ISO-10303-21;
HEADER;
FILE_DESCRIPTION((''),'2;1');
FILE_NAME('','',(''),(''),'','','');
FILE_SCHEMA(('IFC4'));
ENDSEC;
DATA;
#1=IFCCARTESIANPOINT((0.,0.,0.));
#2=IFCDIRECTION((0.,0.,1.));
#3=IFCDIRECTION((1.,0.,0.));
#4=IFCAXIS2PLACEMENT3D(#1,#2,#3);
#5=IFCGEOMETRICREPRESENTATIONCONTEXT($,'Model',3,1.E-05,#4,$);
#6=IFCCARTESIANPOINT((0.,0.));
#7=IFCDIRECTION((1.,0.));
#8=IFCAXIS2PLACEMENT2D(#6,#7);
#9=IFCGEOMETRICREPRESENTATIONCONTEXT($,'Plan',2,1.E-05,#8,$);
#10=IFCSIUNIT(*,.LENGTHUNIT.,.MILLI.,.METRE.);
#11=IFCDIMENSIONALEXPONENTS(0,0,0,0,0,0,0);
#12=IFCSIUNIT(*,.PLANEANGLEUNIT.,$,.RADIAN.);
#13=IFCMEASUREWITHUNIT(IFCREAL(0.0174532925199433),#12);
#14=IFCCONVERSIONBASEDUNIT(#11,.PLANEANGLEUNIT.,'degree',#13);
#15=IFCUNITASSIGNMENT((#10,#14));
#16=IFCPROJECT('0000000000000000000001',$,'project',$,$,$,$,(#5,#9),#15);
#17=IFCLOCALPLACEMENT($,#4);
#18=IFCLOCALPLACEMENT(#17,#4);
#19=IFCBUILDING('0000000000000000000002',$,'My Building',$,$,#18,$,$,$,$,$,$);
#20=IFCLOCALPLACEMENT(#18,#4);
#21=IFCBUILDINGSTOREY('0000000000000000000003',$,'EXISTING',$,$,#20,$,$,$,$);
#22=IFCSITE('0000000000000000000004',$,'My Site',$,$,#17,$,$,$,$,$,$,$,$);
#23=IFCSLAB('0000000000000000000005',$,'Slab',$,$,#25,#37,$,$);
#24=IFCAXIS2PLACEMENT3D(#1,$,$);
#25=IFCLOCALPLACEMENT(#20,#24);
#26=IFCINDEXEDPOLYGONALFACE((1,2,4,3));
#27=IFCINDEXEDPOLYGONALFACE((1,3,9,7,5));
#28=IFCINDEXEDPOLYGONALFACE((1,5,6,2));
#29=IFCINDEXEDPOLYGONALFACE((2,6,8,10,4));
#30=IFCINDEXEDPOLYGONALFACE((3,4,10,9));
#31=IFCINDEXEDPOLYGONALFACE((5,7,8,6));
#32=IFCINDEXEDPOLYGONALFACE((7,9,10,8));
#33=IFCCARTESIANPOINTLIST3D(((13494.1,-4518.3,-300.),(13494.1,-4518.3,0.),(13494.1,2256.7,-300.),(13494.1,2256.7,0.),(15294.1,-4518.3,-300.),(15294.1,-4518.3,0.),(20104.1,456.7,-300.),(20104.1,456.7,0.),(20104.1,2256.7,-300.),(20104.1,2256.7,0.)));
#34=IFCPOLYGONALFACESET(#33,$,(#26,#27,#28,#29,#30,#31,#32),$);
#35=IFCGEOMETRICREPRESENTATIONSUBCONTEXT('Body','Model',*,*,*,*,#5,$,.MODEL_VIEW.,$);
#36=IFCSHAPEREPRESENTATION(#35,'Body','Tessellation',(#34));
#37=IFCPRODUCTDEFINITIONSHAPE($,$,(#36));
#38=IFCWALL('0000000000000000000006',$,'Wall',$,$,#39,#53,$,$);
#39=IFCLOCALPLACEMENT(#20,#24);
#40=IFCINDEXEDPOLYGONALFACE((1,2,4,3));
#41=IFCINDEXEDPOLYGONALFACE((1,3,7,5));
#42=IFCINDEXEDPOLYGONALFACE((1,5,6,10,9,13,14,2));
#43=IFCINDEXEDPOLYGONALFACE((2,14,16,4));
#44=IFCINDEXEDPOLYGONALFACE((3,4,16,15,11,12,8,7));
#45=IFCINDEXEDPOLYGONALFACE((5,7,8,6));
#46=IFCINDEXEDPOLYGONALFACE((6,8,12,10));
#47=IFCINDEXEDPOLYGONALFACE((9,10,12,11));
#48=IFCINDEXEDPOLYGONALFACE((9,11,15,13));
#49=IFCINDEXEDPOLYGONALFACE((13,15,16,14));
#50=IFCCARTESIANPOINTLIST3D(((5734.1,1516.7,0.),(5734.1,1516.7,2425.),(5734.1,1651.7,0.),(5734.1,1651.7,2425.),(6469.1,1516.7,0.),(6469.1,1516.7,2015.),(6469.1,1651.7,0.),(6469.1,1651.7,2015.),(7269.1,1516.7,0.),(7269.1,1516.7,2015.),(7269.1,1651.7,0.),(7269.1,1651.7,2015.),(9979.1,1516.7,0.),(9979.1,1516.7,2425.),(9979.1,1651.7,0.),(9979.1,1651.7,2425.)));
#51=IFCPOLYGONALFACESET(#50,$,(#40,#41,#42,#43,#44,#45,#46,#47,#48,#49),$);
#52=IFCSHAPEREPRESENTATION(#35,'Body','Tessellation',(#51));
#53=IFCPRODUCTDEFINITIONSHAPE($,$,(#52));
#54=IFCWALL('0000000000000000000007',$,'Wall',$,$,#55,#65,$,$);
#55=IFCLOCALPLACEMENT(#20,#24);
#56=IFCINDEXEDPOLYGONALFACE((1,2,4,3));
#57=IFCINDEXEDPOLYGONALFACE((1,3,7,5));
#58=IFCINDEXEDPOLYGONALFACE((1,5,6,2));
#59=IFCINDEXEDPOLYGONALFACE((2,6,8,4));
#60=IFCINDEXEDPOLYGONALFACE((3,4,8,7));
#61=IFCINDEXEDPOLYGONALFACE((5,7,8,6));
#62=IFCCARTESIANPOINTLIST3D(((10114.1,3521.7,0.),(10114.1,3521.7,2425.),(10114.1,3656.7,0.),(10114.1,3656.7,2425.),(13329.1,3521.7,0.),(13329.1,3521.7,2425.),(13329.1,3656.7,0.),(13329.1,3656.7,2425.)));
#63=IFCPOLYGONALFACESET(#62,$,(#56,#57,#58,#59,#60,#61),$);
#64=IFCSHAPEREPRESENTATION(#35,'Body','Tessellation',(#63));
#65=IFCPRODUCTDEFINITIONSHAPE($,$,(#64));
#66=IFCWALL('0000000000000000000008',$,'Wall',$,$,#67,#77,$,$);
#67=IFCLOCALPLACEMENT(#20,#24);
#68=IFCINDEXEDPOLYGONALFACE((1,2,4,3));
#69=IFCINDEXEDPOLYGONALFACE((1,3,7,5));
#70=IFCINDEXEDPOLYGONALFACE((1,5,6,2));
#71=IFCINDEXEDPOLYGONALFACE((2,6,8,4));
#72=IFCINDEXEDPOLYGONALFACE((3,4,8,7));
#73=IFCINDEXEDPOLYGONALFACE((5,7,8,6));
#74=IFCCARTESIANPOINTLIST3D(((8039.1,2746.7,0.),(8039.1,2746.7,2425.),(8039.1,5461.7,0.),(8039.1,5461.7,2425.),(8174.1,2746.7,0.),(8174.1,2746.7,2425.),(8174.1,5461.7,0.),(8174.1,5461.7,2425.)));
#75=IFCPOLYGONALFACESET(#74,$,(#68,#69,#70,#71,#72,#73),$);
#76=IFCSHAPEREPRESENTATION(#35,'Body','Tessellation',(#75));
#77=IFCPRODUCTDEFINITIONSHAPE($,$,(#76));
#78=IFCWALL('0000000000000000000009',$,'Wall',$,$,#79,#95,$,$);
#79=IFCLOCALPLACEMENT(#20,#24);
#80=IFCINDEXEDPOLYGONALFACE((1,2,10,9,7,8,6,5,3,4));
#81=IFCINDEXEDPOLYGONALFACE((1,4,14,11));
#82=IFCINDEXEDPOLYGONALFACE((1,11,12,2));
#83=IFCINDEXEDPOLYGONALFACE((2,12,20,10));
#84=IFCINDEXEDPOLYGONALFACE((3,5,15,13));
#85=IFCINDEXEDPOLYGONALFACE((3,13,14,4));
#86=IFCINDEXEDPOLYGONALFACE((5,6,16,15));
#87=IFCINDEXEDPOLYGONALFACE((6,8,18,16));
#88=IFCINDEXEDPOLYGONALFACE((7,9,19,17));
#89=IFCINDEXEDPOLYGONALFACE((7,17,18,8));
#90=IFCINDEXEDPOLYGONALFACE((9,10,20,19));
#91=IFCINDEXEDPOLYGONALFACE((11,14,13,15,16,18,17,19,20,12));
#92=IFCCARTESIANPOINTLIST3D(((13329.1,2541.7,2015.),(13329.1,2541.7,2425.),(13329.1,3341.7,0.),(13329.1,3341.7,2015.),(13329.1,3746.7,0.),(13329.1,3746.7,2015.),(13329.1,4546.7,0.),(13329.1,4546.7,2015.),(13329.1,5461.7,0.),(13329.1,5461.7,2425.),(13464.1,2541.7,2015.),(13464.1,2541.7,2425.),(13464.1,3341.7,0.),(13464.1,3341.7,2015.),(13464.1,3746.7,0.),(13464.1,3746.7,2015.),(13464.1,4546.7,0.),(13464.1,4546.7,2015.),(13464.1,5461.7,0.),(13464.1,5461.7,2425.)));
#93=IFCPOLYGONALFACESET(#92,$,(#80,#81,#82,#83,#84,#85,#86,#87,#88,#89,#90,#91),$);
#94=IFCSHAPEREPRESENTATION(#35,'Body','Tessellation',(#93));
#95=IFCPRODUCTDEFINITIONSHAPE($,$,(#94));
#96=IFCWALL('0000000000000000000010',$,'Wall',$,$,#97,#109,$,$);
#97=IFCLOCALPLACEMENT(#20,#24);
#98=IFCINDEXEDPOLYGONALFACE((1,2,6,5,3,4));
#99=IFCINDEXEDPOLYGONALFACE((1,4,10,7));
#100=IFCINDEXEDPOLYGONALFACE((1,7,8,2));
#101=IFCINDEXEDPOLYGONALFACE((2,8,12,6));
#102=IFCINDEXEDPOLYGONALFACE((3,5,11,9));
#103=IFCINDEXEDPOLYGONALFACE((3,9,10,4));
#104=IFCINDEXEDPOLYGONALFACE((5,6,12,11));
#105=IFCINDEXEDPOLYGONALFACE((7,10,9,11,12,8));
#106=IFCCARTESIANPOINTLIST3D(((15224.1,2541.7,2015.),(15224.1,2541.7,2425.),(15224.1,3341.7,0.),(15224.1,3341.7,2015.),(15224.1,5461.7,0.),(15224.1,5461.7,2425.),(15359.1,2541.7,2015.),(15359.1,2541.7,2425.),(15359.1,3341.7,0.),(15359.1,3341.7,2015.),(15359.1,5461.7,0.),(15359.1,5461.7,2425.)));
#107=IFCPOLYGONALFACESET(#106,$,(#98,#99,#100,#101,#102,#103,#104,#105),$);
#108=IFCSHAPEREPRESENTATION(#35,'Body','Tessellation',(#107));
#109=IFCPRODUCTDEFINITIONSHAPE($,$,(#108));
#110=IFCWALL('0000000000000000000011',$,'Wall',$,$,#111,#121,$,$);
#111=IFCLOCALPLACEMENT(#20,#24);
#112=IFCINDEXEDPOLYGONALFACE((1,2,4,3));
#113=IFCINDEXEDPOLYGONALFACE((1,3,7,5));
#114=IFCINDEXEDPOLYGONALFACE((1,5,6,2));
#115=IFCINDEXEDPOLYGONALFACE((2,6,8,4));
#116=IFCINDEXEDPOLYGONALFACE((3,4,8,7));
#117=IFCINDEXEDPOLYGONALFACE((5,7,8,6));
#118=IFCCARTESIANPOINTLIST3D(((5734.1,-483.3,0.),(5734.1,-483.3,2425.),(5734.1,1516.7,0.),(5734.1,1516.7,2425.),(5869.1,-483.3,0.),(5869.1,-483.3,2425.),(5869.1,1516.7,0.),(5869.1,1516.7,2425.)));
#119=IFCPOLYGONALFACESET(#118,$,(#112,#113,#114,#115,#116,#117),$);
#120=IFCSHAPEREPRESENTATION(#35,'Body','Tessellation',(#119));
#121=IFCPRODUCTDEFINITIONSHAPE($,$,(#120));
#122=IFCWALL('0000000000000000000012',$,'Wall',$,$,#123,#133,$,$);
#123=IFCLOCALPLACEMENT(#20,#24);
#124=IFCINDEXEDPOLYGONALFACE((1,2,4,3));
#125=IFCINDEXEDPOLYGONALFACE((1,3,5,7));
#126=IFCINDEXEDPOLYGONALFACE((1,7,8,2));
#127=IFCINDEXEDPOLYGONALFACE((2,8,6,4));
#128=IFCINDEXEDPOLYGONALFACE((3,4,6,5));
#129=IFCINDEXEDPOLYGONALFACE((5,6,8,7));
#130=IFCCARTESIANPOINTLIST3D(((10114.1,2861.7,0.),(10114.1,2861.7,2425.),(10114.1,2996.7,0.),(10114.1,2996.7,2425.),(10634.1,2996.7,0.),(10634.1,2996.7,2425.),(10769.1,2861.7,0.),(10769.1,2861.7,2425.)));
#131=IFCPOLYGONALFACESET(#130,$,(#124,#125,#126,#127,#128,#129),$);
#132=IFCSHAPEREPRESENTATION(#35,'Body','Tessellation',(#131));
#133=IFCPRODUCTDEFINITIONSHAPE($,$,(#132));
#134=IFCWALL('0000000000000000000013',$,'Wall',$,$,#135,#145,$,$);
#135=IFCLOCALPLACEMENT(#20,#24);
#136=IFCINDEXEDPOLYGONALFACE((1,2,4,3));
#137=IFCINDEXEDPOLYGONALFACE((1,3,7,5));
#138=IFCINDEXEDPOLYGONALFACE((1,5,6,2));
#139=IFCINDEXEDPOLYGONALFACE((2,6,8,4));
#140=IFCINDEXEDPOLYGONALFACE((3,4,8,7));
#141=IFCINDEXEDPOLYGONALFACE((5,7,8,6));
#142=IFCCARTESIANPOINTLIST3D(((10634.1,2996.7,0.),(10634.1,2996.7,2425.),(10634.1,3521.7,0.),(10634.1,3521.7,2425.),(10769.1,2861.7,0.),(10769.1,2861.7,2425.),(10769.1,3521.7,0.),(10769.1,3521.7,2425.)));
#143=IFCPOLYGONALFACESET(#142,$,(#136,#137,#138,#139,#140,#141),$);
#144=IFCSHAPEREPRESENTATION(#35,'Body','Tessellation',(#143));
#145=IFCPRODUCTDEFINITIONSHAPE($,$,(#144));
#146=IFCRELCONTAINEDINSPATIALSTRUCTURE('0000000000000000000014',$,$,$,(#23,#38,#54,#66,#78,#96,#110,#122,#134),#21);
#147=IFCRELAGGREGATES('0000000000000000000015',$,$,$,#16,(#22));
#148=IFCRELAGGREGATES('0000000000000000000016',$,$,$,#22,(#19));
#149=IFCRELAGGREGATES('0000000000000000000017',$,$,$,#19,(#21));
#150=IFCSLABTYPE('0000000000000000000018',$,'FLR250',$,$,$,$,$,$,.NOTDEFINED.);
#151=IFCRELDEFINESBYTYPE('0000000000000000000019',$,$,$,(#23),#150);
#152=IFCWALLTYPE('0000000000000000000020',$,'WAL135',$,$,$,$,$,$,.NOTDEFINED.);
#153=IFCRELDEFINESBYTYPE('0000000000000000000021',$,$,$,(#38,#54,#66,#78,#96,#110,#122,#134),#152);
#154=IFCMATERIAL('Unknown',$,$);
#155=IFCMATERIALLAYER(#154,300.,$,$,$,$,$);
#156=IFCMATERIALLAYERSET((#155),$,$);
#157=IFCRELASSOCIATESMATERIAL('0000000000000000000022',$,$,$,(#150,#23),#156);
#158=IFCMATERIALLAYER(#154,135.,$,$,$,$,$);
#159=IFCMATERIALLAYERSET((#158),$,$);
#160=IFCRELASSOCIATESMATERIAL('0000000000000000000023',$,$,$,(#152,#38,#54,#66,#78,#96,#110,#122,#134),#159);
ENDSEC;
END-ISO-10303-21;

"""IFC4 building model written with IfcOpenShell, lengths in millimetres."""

from ifc_helpers import new_model, entity, si_unit, converted_unit, frame, origin_with_axes, origin_2d_with_axis, place, context, subcontext, project, spatial, line, indexed_curve, outline, extrude, clip, halfspace, source, transform, mapped, material, layer, layer_set, layer_usage, type_object, element, save


model = new_model("IFC4")

# Units and contexts
model_context = context("Model", 3, precision=1e-05, world=origin_with_axes())
plan_context = context("Plan", 2, precision=1e-05, world=origin_2d_with_axis())
body_context = subcontext(model_context, "Body", "Model", "MODEL_VIEW")
ifc_project = project(units=[si_unit("LENGTHUNIT", "METRE", prefix="MILLI"), converted_unit("PLANEANGLEUNIT", "degree", entity("IfcReal", 0.0174532925199433), si_unit("PLANEANGLEUNIT", "RADIAN"), dimensions=[0, 0, 0, 0, 0, 0, 0])], contexts=[model_context, plan_context])

# Site, building, storey
site_placement = place(None, origin_with_axes())
site = spatial("IfcSite", under=ifc_project, at=site_placement, Name="My Site")
building_placement = place(site_placement, origin_with_axes())
building = spatial("IfcBuilding", under=site, at=building_placement, Name="My Building")
storey_placement = place(building_placement, origin_with_axes())
storey = spatial("IfcBuildingStorey", under=building, at=storey_placement, Name="EXISTING")

# Slab
ifc_material = material(Name="Unknown")
ifc_layer_1 = layer(ifc_material, 300.0)
ifc_layer_set_1 = layer_set([ifc_layer_1])
ifc_layer_usage_1 = layer_usage(ifc_layer_set_1, "AXIS3", "POSITIVE", 0.0)
slab_type = type_object("IfcSlabType", Name="FLR250", PredefinedType="NOTDEFINED", material=ifc_layer_set_1)
slab_placement = place(storey_placement, frame((13494.1, -4518.3, -300.0), z_axis=(0.0, 0.0, 1.0), x_axis=(1.0, 0.0, 0.0)))
element("IfcSlab", 1, at=slab_placement, inside=storey, type_object=slab_type, material=ifc_layer_usage_1, Name="Slab", context=body_context, shape_type="SweptSolid", body=[
    extrude(outline(indexed_curve([(0.0, 0.0), (6610.0, 4975.0), (6610.0, 6775.0), (0.0, 6775.0), (1800.0, 0.0)], segments=[line(3, 2), line(2, 5), line(5, 1), line(1, 4), line(4, 3)], self_intersect=False)), None, (0.0, 0.0, 1.0), 300.0),
])

# Wall, opening
ifc_layer_2 = layer(ifc_material, 135.0)
ifc_layer_set_2 = layer_set([ifc_layer_2])
ifc_layer_usage_2 = layer_usage(ifc_layer_set_2, "AXIS2", "POSITIVE", 0.0)
wall_type_1 = type_object("IfcWallType", Name="WAL135", PredefinedType="NOTDEFINED", material=ifc_layer_set_2)
wall_1_placement = place(storey_placement, frame((5734.1, 1516.7, 0.0), z_axis=(0.0, 0.0, 1.0), x_axis=(1.0, 0.0, 0.0)))
wall_1 = element("IfcWall", 2, at=wall_1_placement, inside=storey, type_object=wall_type_1, material=ifc_layer_usage_2, Name="Wall", context=body_context, shape_type="SweptSolid", body=[
    extrude(outline(indexed_curve([(0.0, 0.0), (0.0, 135.0), (4245.0, 135.0), (4245.0, 0.0), (0.0, 0.0)], self_intersect=False)), origin_with_axes(), (0.0, 0.0, 1.0), 2425.0),
])
shared_shape_1 = source(origin_with_axes(), body_context, "Body", "SweptSolid", [
    extrude(outline(indexed_curve([(0.0, 0.0), (800.0, 0.0), (800.0, 2015.0), (0.0, 2015.0)], segments=[line(1, 2, 3, 4, 1)])), frame((0.0, -600.0, 0.0), z_axis=(0.0, -1.0, 0.0), x_axis=(1.0, 0.0, 0.0)), (0.0, 0.0, -1.0), 1200.0),
])
opening_1_placement = place(wall_1_placement, frame((735.0, 78.7, 0.0), z_axis=(0.0, 0.0, 1.0), x_axis=(1.0, 0.0, 0.0)))
element("IfcOpeningElement", 3, at=opening_1_placement, cuts=wall_1, PredefinedType="OPENING", context=body_context, shape_type="MappedRepresentation", body=[
    mapped(shared_shape_1, transform((0.0, 0.0, 0.0), x_axis=(1.0, 0.0, 0.0), y_axis=(0.0, 1.0, 0.0), z_axis=(0.0, 0.0, 1.0), scale=1.0)),
])

# Walls
ifc_layer_usage_3 = layer_usage(ifc_layer_set_2, "AXIS2", "POSITIVE", 0.0)
wall_2_placement = place(storey_placement, frame((10114.1, 3521.7, 0.0), z_axis=(0.0, 0.0, 1.0), x_axis=(1.0, 0.0, 0.0)))
element("IfcWall", 4, at=wall_2_placement, inside=storey, type_object=wall_type_1, material=ifc_layer_usage_3, Name="Wall", context=body_context, shape_type="SweptSolid", body=[
    extrude(outline(indexed_curve([(0.0, 0.0), (0.0, 135.0), (3215.0, 135.0), (3215.0, 0.0), (0.0, 0.0)], self_intersect=False)), origin_with_axes(), (0.0, 0.0, 1.0), 2425.0),
])
ifc_layer_usage_4 = layer_usage(ifc_layer_set_2, "AXIS2", "POSITIVE", 0.0)
wall_3_placement = place(storey_placement, frame((8039.1, 5461.7, 0.0), z_axis=(0.0, 0.0, 1.0), x_axis=(0.0, -1.0, 0.0)))
element("IfcWall", 5, at=wall_3_placement, inside=storey, type_object=wall_type_1, material=ifc_layer_usage_4, Name="Wall", context=body_context, shape_type="SweptSolid", body=[
    extrude(outline(indexed_curve([(0.0, 0.0), (0.0, 135.0), (2715.0, 135.0), (2715.0, 0.0), (0.0, 0.0)], self_intersect=False)), origin_with_axes(), (0.0, 0.0, 1.0), 2425.0),
])

# Wall, openings
ifc_layer_usage_5 = layer_usage(ifc_layer_set_2, "AXIS2", "POSITIVE", 0.0)
wall_4_placement = place(storey_placement, frame((13329.1, 5461.7, 0.0), z_axis=(0.0, 0.0, 1.0), x_axis=(0.0, -1.0, 0.0)))
wall_4 = element("IfcWall", 6, at=wall_4_placement, inside=storey, type_object=wall_type_1, material=ifc_layer_usage_5, Name="Wall", context=body_context, shape_type="SweptSolid", body=[
    extrude(outline(indexed_curve([(0.0, 0.0), (0.0, 135.0), (2920.0, 135.0), (2920.0, 0.0), (0.0, 0.0)], self_intersect=False)), origin_with_axes(), (0.0, 0.0, 1.0), 2425.0),
])
opening_2_placement = place(wall_4_placement, frame((2120.0, 73.6, 0.0), z_axis=(0.0, 0.0, 1.0), x_axis=(1.0, 0.0, 0.0)))
element("IfcOpeningElement", 7, at=opening_2_placement, cuts=wall_4, PredefinedType="OPENING", context=body_context, shape_type="MappedRepresentation", body=[
    mapped(shared_shape_1, transform((0.0, 0.0, 0.0), x_axis=(1.0, 0.0, 0.0), y_axis=(0.0, 1.0, 0.0), z_axis=(0.0, 0.0, 1.0), scale=1.0)),
])
opening_3_placement = place(wall_4_placement, frame((915.0, 78.7, 0.0), z_axis=(0.0, 0.0, 1.0), x_axis=(1.0, 0.0, 0.0)))
element("IfcOpeningElement", 8, at=opening_3_placement, cuts=wall_4, PredefinedType="OPENING", context=body_context, shape_type="MappedRepresentation", body=[
    mapped(shared_shape_1, transform((0.0, 0.0, 0.0), x_axis=(1.0, 0.0, 0.0), y_axis=(0.0, 1.0, 0.0), z_axis=(0.0, 0.0, 1.0), scale=1.0)),
])

# Wall, opening
ifc_layer_usage_6 = layer_usage(ifc_layer_set_2, "AXIS2", "POSITIVE", 0.0)
wall_5_placement = place(storey_placement, frame((15224.1, 5461.7, 0.0), z_axis=(0.0, 0.0, 1.0), x_axis=(0.0, -1.0, 0.0)))
wall_5 = element("IfcWall", 9, at=wall_5_placement, inside=storey, type_object=wall_type_1, material=ifc_layer_usage_6, Name="Wall", context=body_context, shape_type="SweptSolid", body=[
    extrude(outline(indexed_curve([(0.0, 0.0), (0.0, 135.0), (2920.0, 135.0), (2920.0, 0.0), (0.0, 0.0)], self_intersect=False)), origin_with_axes(), (0.0, 0.0, 1.0), 2425.0),
])
opening_4_placement = place(wall_5_placement, frame((2120.0, 0.0, 0.0), z_axis=(0.0, 0.0, 1.0), x_axis=(1.0, 0.0, 0.0)))
element("IfcOpeningElement", 10, at=opening_4_placement, cuts=wall_5, PredefinedType="OPENING", context=body_context, shape_type="MappedRepresentation", body=[
    mapped(shared_shape_1, transform((0.0, 0.0, 0.0), x_axis=(1.0, 0.0, 0.0), y_axis=(0.0, 1.0, 0.0), z_axis=(0.0, 0.0, 1.0), scale=1.0)),
])

# Walls
ifc_layer_usage_7 = layer_usage(ifc_layer_set_2, "AXIS2", "POSITIVE", 0.0)
wall_6_placement = place(storey_placement, frame((5734.1, 1516.7, 0.0), z_axis=(0.0, 0.0, 1.0), x_axis=(0.0, -1.0, 0.0)))
element("IfcWall", 11, at=wall_6_placement, inside=storey, type_object=wall_type_1, material=ifc_layer_usage_7, Name="Wall", context=body_context, shape_type="SweptSolid", body=[
    extrude(outline(indexed_curve([(0.0, 0.0), (0.0, 135.0), (2000.0, 135.0), (2000.0, 0.0), (0.0, 0.0)], self_intersect=False)), origin_with_axes(), (0.0, 0.0, 1.0), 2425.0),
])
ifc_layer_usage_8 = layer_usage(ifc_layer_set_2, "AXIS2", "POSITIVE", 0.0)
wall_7_placement = place(storey_placement, frame((10114.1, 2861.7, 0.0), z_axis=(0.0, 0.0, 1.0), x_axis=(1.0, 0.0, 0.0)))
element("IfcWall", 12, at=wall_7_placement, inside=storey, type_object=wall_type_1, material=ifc_layer_usage_8, Name="Wall", context=body_context, shape_type="Clipping", body=[
    clip(extrude(outline(indexed_curve([(0.0, 0.0), (0.0, 135.0), (655.0, 135.0), (655.0, 0.0), (0.0, 0.0)], self_intersect=False)), origin_with_axes(), (0.0, 0.0, 1.0), 2425.0), halfspace(frame((655.0, 0.0, 0.0), z_axis=(0.707107, 0.707107, 0.0), x_axis=(0.707107, -0.707107, 0.0)), False)),
])
ifc_layer_usage_9 = layer_usage(ifc_layer_set_2, "AXIS2", "POSITIVE", 0.0)
wall_8_placement = place(storey_placement, frame((10769.1, 2861.7, 0.0), z_axis=(0.0, 0.0, 1.0), x_axis=(0.0, 1.0, 0.0)))
element("IfcWall", 13, at=wall_8_placement, inside=storey, type_object=wall_type_1, material=ifc_layer_usage_9, Name="Wall", context=body_context, shape_type="Clipping", body=[
    clip(extrude(outline(indexed_curve([(0.0, 0.0), (0.0, 135.0), (660.0, 135.0), (660.0, 0.0), (0.0, 0.0)], self_intersect=False)), origin_with_axes(), (0.0, 0.0, 1.0), 2425.0), halfspace(frame((0.0, 0.0, 0.0), z_axis=(-0.707107, 0.707107, 0.0), x_axis=(0.707107, 0.707107, 0.0)), False)),
])

save(model, "model.ifc")
